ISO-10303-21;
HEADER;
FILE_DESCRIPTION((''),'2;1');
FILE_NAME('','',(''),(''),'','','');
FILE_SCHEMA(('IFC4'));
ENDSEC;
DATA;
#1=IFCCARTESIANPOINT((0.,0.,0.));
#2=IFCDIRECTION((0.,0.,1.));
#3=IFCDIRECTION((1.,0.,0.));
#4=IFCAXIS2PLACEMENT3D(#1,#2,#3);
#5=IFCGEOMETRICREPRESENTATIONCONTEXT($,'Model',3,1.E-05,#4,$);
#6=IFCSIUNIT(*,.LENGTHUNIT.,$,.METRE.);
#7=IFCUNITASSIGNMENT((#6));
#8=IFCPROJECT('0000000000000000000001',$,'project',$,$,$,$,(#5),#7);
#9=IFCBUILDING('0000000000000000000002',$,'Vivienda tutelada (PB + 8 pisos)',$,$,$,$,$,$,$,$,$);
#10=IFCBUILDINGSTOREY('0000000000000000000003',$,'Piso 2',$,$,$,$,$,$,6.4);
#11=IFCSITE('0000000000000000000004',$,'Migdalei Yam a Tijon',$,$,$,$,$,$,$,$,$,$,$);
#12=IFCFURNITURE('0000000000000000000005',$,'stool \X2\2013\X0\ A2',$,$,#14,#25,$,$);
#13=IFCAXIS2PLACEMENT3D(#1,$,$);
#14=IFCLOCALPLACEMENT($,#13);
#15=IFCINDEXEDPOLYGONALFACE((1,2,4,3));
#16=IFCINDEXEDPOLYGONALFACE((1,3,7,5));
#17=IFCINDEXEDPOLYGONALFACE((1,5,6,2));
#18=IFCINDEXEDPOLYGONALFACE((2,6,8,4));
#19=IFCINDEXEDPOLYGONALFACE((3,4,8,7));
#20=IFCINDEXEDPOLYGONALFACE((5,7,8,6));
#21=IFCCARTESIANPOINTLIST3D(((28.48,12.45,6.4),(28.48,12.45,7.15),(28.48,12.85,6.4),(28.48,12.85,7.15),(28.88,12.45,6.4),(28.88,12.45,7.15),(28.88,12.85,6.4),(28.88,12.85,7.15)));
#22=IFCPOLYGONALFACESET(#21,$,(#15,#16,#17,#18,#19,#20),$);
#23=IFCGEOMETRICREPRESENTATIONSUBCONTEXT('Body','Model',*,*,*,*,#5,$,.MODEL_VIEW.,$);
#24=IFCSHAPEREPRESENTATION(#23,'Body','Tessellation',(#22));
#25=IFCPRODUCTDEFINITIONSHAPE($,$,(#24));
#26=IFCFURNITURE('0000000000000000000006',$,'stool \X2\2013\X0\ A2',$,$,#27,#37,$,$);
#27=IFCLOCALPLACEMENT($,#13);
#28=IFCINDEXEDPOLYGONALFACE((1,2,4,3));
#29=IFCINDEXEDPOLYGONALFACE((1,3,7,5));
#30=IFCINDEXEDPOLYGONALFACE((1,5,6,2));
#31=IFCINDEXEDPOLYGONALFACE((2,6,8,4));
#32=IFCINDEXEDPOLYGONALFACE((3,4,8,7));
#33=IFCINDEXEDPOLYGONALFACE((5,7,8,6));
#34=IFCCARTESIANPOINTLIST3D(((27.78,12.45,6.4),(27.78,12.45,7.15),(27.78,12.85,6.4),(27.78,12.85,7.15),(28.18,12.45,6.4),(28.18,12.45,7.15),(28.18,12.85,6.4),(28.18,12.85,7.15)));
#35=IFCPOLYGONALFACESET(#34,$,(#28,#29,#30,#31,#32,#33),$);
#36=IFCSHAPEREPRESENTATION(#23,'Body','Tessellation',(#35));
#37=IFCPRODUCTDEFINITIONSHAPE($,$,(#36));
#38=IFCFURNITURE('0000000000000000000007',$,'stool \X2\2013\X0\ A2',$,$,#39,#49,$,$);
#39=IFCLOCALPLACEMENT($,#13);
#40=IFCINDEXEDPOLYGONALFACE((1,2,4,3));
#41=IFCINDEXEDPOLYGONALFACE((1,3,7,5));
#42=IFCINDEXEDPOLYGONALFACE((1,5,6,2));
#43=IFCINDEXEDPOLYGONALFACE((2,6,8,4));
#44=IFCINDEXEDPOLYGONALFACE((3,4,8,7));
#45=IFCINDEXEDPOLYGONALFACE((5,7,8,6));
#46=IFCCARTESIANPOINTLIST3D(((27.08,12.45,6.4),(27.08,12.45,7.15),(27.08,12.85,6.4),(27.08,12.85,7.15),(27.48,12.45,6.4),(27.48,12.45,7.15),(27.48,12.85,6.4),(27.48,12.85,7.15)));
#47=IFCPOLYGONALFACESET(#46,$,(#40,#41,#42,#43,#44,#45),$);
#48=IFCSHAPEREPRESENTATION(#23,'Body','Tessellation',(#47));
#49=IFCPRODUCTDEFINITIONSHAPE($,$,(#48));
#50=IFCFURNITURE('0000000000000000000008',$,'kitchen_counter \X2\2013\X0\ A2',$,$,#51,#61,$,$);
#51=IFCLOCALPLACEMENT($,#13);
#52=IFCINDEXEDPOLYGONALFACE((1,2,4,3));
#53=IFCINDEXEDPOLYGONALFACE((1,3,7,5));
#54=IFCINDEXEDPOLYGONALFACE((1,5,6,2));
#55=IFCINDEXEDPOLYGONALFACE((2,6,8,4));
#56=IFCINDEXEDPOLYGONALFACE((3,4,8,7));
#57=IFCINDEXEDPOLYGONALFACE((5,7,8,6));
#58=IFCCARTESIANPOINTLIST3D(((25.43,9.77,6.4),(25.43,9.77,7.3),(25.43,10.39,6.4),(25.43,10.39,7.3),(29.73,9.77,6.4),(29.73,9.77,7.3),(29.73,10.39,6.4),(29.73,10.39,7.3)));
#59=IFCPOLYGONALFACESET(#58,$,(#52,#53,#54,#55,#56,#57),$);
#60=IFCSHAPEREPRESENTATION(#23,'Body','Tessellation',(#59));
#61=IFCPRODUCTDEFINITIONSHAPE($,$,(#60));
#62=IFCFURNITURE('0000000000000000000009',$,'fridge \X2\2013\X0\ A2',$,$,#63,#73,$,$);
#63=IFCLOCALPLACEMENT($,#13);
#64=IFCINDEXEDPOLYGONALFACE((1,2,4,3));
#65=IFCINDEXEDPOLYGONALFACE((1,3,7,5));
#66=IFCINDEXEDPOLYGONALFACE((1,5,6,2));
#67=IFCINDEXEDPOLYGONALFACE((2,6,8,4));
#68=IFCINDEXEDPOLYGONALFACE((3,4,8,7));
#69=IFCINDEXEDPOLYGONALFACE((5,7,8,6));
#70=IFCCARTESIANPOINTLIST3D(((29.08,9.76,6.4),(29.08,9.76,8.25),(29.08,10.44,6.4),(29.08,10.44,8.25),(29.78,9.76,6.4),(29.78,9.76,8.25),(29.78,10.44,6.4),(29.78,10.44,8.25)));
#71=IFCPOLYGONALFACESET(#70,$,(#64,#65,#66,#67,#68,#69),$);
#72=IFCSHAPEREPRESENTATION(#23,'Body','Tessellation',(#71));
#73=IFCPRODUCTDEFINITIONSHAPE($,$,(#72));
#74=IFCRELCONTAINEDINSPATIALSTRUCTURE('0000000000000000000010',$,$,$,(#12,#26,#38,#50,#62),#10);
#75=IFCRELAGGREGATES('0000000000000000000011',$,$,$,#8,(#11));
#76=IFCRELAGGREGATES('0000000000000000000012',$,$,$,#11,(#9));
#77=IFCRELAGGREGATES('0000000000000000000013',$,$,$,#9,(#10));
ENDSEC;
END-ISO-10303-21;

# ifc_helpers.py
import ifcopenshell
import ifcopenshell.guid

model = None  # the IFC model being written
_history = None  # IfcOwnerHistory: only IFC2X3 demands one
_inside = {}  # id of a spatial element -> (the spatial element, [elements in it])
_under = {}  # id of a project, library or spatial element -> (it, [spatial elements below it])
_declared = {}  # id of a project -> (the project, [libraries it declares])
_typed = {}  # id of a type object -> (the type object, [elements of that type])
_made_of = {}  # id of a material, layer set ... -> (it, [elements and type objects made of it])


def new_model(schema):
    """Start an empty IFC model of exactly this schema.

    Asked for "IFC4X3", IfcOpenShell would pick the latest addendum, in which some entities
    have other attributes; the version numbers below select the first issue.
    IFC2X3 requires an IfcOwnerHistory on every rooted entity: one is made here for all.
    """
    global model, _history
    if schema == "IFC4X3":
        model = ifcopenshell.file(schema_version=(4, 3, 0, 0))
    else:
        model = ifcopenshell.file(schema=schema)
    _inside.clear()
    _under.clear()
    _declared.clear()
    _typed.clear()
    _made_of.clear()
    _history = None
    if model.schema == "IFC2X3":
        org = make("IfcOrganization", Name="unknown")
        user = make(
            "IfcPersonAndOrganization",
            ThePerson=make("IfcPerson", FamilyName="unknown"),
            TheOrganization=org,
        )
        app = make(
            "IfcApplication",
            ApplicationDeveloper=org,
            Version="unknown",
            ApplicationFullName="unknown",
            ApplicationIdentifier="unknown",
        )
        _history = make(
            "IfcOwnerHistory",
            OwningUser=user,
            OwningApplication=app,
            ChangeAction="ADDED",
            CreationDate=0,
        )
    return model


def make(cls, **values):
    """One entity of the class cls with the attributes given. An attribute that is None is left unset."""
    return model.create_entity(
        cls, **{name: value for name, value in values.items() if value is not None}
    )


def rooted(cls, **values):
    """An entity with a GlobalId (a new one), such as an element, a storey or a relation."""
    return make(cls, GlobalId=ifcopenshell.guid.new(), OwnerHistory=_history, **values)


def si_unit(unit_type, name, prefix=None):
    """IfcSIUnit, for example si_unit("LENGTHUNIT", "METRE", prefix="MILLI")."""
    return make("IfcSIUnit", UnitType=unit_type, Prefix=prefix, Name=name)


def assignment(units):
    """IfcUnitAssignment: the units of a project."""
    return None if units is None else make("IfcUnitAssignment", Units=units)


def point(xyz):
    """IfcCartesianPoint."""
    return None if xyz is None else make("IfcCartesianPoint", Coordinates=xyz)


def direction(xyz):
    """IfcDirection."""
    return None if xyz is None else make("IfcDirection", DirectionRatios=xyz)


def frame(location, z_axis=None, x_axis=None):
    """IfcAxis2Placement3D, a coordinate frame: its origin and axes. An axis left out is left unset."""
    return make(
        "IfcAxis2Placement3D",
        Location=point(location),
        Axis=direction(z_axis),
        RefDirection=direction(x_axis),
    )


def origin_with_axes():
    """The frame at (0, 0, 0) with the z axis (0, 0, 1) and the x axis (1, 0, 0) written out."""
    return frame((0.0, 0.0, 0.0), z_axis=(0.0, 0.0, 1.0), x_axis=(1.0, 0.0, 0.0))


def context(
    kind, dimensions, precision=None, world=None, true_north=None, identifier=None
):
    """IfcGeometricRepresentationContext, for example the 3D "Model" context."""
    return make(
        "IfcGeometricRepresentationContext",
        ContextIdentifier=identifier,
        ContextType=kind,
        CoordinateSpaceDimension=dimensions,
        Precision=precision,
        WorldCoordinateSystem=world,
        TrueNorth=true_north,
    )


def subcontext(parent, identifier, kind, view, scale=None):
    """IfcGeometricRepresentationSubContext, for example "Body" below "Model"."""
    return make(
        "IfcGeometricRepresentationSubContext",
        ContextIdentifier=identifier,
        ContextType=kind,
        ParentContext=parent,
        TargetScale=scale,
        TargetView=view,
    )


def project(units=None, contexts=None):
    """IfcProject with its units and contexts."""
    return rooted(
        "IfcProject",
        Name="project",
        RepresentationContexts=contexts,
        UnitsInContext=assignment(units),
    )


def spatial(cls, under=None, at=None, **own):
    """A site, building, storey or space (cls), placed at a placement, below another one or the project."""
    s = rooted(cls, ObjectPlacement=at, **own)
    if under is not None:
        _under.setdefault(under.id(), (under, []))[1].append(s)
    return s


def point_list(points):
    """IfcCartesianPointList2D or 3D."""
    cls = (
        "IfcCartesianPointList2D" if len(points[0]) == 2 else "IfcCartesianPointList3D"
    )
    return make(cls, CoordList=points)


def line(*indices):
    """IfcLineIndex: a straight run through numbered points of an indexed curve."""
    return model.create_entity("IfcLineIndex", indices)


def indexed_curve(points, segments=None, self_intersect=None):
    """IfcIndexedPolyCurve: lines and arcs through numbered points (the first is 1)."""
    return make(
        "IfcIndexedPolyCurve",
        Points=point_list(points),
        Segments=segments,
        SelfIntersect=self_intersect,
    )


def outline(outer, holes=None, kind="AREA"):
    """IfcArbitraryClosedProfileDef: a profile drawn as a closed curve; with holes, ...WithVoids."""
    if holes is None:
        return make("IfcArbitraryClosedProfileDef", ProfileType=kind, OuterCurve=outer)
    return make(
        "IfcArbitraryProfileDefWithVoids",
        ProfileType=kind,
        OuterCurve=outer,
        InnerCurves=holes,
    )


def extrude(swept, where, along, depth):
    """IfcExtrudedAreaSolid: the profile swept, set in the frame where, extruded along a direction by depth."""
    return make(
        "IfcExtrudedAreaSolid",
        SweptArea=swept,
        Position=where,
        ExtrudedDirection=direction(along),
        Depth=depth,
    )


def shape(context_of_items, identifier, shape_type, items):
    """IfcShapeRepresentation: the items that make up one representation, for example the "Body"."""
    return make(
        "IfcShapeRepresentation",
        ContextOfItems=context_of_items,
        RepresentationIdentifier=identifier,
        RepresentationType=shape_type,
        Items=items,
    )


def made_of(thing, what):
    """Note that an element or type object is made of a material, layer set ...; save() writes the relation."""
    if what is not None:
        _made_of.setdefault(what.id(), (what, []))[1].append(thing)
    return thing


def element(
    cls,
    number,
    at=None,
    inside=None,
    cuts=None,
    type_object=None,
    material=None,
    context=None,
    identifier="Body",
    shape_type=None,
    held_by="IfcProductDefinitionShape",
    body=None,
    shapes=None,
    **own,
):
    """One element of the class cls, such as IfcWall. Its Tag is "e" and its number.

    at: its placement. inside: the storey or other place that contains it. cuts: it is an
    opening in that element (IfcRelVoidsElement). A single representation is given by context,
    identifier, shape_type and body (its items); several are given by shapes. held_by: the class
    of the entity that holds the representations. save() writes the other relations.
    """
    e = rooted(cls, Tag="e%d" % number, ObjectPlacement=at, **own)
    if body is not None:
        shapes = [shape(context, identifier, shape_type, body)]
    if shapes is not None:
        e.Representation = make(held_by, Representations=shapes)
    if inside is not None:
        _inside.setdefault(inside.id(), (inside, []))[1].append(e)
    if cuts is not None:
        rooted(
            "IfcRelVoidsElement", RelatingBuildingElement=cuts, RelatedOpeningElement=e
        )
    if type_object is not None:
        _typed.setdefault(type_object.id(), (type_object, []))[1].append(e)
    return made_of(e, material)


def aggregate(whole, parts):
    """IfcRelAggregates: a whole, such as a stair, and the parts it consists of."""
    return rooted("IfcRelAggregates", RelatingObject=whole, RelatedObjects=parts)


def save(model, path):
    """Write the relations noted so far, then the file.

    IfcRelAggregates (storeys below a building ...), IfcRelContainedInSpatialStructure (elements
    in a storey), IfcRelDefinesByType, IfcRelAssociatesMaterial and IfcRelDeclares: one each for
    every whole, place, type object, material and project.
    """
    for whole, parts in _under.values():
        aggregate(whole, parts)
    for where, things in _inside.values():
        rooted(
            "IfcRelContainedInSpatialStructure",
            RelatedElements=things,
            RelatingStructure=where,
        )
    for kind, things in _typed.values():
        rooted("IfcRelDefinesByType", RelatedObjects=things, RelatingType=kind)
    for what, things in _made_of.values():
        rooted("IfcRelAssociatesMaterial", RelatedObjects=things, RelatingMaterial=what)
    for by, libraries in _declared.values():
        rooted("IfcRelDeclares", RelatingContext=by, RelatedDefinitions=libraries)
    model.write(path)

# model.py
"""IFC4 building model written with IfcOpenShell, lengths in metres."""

from ifc_helpers import new_model, si_unit, frame, origin_with_axes, context, subcontext, project, spatial, line, indexed_curve, outline, extrude, element, save


model = new_model("IFC4")

# Units and contexts
model_context = context("Model", 3, precision=1e-05, world=origin_with_axes())
body_context = subcontext(model_context, "Body", "Model", "MODEL_VIEW")
ifc_project = project(units=[si_unit("LENGTHUNIT", "METRE")], contexts=[model_context])

# Site, building, storey
site = spatial("IfcSite", under=ifc_project, Name="Migdalei Yam a Tijon")
building = spatial("IfcBuilding", under=site, Name="Vivienda tutelada (PB + 8 pisos)")
storey = spatial("IfcBuildingStorey", under=building, Name="Piso 2", Elevation=6.4)

# Furniture
element("IfcFurniture", 1, inside=storey, Name="stool – A2", context=body_context, shape_type="SweptSolid", body=[
    extrude(outline(indexed_curve([(0.0, 0.0), (0.4, 0.0), (0.4, 0.4), (0.0, 0.4)], segments=[line(1, 2, 3, 4, 1)])), frame((28.48, 12.45, 6.4), z_axis=(0.0, 0.0, 1.0), x_axis=(1.0, 0.0, 0.0)), (0.0, 0.0, 1.0), 0.75),
])
element("IfcFurniture", 2, inside=storey, Name="stool – A2", context=body_context, shape_type="SweptSolid", body=[
    extrude(outline(indexed_curve([(0.0, 0.0), (0.4, 0.0), (0.4, 0.4), (0.0, 0.4)], segments=[line(1, 2, 3, 4, 1)])), frame((27.78, 12.45, 6.4), z_axis=(0.0, 0.0, 1.0), x_axis=(1.0, 0.0, 0.0)), (0.0, 0.0, 1.0), 0.75),
])
element("IfcFurniture", 3, inside=storey, Name="stool – A2", context=body_context, shape_type="SweptSolid", body=[
    extrude(outline(indexed_curve([(0.0, 0.0), (0.4, 0.0), (0.4, 0.4), (0.0, 0.4)], segments=[line(1, 2, 3, 4, 1)])), frame((27.08, 12.45, 6.4), z_axis=(0.0, 0.0, 1.0), x_axis=(1.0, 0.0, 0.0)), (0.0, 0.0, 1.0), 0.75),
])
element("IfcFurniture", 4, inside=storey, Name="kitchen_counter – A2", context=body_context, shape_type="SweptSolid", body=[
    extrude(outline(indexed_curve([(0.0, 0.0), (4.3, 0.0), (4.3, 0.62), (0.0, 0.62)], segments=[line(1, 2, 3, 4, 1)])), frame((25.43, 9.77, 6.4), z_axis=(0.0, 0.0, 1.0), x_axis=(1.0, 0.0, 0.0)), (0.0, 0.0, 1.0), 0.9),
])
element("IfcFurniture", 5, inside=storey, Name="fridge – A2", context=body_context, shape_type="SweptSolid", body=[
    extrude(outline(indexed_curve([(0.0, 0.0), (0.7, 0.0), (0.7, 0.68), (0.0, 0.68)], segments=[line(1, 2, 3, 4, 1)])), frame((29.08, 9.76, 6.4), z_axis=(0.0, 0.0, 1.0), x_axis=(1.0, 0.0, 0.0)), (0.0, 0.0, 1.0), 1.85),
])

save(model, "model.ifc")
